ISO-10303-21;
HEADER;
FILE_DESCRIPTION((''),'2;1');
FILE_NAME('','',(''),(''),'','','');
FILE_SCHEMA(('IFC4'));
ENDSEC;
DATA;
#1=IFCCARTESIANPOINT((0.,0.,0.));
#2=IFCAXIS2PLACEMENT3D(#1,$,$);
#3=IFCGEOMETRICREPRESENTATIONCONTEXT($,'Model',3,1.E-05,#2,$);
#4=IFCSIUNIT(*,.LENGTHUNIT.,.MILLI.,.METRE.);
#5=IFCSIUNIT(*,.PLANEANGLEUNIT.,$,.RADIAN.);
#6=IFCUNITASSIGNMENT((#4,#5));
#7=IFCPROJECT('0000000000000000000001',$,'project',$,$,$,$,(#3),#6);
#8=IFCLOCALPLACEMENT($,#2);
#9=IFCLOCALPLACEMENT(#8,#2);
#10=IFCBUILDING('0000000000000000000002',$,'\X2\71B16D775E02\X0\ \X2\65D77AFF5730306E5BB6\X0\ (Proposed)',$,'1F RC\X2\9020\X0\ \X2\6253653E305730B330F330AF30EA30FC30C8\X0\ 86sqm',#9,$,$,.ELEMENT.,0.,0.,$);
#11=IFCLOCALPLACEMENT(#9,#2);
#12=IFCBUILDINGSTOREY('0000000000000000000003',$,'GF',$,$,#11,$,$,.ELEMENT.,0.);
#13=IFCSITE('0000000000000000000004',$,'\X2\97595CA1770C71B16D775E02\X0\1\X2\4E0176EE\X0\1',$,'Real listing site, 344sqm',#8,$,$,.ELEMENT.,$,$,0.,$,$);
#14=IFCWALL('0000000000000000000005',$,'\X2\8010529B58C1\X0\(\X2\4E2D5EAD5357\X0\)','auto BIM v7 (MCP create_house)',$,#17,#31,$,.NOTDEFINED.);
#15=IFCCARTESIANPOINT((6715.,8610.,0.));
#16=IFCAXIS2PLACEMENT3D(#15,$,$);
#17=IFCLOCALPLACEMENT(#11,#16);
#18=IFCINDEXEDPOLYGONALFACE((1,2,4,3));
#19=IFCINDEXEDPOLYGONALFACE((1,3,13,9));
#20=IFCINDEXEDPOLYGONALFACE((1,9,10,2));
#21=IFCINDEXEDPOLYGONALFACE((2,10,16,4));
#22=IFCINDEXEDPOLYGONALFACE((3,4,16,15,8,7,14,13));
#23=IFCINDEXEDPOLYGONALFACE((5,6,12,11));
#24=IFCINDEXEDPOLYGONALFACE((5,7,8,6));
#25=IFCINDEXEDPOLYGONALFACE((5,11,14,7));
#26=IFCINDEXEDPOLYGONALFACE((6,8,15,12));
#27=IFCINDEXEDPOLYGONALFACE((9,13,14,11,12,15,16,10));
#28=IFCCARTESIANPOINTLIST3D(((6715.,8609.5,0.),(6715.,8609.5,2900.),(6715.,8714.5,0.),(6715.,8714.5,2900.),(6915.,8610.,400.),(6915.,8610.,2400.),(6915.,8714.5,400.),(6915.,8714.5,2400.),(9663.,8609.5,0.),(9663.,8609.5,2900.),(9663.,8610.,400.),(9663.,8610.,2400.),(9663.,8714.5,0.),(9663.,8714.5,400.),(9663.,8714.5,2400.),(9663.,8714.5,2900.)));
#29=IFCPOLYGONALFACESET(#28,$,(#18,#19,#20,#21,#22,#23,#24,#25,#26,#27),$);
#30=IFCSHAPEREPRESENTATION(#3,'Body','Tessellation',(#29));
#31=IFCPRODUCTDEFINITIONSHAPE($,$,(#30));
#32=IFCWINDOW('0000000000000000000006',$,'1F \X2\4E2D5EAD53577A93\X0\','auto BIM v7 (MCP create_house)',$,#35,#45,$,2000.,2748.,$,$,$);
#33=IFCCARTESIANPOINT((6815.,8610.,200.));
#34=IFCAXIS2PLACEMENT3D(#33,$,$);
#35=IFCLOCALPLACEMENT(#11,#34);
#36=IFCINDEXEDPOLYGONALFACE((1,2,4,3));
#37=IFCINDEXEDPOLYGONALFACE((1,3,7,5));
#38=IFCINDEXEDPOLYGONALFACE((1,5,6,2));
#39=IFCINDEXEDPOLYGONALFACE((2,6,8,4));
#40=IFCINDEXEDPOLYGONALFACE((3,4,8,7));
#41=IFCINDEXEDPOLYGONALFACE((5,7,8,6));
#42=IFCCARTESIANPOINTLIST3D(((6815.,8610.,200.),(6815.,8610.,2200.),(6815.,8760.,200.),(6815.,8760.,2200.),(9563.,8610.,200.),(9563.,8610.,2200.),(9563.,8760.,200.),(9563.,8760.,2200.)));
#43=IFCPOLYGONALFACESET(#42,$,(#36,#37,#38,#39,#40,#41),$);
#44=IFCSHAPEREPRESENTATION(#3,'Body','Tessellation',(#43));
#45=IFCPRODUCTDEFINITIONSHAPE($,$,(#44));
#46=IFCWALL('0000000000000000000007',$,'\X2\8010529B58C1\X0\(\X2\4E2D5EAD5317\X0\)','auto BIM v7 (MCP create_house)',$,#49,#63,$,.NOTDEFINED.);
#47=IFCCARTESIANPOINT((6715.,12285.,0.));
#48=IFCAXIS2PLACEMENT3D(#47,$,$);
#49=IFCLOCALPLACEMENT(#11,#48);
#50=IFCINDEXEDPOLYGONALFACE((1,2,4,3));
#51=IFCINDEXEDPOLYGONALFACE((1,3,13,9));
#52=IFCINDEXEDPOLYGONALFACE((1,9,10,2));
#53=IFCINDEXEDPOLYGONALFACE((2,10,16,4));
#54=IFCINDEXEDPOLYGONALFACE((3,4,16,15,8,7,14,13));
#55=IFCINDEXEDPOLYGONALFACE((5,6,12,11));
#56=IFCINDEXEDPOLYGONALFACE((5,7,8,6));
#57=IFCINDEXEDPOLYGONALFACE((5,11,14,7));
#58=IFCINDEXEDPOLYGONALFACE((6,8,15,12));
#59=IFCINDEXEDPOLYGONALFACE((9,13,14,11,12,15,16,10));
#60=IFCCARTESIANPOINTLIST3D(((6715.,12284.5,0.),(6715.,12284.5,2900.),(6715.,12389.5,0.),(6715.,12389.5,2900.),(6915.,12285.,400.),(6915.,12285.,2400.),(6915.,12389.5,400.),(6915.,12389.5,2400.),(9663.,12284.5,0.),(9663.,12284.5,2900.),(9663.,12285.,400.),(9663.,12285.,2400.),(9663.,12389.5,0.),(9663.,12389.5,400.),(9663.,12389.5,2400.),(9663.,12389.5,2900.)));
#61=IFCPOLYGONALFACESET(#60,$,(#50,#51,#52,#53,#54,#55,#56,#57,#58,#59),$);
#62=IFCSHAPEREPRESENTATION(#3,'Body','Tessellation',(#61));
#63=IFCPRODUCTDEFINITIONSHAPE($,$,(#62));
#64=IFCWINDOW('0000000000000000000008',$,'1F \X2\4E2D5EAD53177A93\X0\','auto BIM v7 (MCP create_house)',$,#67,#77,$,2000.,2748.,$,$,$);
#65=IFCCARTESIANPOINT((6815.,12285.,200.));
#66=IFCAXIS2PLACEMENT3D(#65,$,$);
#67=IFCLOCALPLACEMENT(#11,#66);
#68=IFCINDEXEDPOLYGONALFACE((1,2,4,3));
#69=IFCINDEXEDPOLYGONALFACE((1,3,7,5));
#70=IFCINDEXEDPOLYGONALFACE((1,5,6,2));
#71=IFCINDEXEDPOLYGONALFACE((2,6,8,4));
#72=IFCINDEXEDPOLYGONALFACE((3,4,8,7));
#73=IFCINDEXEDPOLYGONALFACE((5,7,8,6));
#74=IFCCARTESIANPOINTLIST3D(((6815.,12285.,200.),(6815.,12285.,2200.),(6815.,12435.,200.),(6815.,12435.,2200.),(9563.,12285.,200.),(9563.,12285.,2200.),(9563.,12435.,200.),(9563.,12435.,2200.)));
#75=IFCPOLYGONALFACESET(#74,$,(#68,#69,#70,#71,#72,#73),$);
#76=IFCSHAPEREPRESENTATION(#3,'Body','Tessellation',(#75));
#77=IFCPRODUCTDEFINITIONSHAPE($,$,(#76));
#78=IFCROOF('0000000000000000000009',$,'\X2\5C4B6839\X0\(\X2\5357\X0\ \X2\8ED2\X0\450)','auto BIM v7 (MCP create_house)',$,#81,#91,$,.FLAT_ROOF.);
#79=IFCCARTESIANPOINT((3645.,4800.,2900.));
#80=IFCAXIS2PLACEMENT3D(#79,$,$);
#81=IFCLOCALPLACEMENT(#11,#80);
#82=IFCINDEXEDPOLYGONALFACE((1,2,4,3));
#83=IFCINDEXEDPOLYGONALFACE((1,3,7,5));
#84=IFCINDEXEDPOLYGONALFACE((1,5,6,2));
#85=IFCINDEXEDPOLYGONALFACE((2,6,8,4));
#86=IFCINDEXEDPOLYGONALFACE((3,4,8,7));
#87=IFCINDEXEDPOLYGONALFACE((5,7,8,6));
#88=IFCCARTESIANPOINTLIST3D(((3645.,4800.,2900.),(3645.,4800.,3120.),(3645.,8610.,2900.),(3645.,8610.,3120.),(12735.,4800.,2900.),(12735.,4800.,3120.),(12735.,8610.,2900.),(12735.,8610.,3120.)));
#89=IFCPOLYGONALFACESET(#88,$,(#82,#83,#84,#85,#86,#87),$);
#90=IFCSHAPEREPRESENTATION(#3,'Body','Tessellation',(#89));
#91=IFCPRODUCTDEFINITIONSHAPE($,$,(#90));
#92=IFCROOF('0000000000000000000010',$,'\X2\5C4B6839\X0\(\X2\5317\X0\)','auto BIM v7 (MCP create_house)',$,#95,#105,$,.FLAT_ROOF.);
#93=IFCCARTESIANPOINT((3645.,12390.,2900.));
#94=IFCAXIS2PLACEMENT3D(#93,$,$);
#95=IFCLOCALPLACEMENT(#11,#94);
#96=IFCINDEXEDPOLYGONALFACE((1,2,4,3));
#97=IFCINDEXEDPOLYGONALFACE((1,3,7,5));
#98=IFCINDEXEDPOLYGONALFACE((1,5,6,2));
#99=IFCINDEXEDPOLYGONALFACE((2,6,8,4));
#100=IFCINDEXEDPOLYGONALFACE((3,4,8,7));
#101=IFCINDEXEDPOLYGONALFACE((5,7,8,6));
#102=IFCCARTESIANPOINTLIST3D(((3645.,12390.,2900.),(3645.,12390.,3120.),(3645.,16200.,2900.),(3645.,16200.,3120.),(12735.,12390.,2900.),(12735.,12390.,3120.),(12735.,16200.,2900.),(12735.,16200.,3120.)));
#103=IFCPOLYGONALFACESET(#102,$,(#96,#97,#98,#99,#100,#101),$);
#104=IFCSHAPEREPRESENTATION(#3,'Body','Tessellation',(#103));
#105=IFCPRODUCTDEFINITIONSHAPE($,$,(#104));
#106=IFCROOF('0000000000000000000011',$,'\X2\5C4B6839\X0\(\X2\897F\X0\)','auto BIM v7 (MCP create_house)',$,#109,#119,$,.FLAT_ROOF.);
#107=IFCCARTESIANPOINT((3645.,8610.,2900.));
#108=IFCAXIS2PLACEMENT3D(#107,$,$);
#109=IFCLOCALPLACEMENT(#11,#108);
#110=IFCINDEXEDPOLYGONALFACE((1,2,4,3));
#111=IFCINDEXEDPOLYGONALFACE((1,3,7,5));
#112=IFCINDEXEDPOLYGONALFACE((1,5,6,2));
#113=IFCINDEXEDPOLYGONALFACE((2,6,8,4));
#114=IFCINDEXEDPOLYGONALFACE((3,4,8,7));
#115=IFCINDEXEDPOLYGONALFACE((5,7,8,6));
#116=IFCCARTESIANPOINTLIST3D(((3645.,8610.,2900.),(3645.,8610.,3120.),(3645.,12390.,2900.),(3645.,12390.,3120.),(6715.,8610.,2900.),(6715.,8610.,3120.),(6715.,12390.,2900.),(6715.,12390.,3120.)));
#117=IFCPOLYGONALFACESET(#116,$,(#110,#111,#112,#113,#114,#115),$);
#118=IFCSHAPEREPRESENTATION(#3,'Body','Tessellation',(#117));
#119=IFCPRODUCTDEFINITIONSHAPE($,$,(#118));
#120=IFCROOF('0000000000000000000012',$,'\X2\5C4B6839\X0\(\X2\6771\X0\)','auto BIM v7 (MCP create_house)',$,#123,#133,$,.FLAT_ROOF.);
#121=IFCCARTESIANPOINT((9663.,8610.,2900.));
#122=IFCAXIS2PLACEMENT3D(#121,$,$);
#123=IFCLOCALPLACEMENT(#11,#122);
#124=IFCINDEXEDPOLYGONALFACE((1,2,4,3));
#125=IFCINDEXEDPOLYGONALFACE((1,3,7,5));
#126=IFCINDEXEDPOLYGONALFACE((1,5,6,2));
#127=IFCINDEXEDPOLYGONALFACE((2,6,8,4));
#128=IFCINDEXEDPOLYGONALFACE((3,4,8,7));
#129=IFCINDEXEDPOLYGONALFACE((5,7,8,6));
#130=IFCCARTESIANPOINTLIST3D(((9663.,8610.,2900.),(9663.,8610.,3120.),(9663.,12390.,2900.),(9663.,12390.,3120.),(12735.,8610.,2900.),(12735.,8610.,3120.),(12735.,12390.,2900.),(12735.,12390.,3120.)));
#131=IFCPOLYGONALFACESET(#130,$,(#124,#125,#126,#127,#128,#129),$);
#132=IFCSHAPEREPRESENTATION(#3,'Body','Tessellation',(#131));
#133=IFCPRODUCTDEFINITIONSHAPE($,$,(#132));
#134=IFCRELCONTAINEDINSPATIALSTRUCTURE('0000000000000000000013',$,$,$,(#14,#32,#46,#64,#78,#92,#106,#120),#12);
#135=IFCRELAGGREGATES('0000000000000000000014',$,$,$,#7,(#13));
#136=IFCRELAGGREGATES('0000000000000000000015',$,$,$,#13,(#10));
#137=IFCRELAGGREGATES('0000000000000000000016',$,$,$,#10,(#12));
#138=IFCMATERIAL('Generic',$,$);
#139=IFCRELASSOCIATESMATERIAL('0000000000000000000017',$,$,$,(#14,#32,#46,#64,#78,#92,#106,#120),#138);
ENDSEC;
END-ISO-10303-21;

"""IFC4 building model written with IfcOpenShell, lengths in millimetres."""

from ifc_helpers import new_model, si_unit, frame, frame_2d, origin, place, context, project, spatial, rectangle, extrude, material, element, fill, save


model = new_model("IFC4")

# Units and contexts
model_context = context("Model", 3, precision=1e-05, world=origin())
ifc_project = project(units=[si_unit("LENGTHUNIT", "METRE", prefix="MILLI"), si_unit("PLANEANGLEUNIT", "RADIAN")], contexts=[model_context])

# Site, building, storey
site_placement = place(None, origin())
site = spatial("IfcSite", under=ifc_project, at=site_placement, Name="静岡県熱海市1丁目1", ObjectType="Real listing site, 344sqm", CompositionType="ELEMENT", RefElevation=0.0)
building_placement = place(site_placement, origin())
building = spatial("IfcBuilding", under=site, at=building_placement, Name="熱海市 旗竿地の家 (Proposed)", ObjectType="1F RC造 打放しコンクリート 86sqm", CompositionType="ELEMENT", ElevationOfRefHeight=0.0, ElevationOfTerrain=0.0)
storey_placement = place(building_placement, origin())
storey = spatial("IfcBuildingStorey", under=building, at=storey_placement, Name="GF", CompositionType="ELEMENT", Elevation=0.0)

# Shared definitions
ifc_material = material(Name="Generic")

# Walls, openings, windows
wall_1_placement = place(storey_placement, frame((6715.0, 8610.0, 0.0)))
wall_1 = element("IfcWall", 1, at=wall_1_placement, inside=storey, material=ifc_material, Name="耐力壁(中庭南)", Description="auto BIM v7 (MCP create_house)", PredefinedType="NOTDEFINED", context=model_context, shape_type="SweptSolid", body=[
    extrude(rectangle(XDim=2948.0, YDim=105.0, at=frame_2d((1474.0, 52.0))), frame((6715.0, 8610.0, 0.0)), (0.0, 0.0, 1.0), 2900.0),
])
opening_1_placement = place(storey_placement, frame((6815.0, 8610.0, 200.0)))
opening_1 = element("IfcOpeningElement", 2, at=opening_1_placement, cuts=wall_1, PredefinedType="NOTDEFINED", context=model_context, shape_type="SweptSolid", body=[
    extrude(rectangle(XDim=2748.0, YDim=150.0, at=frame_2d((1374.0, 75.0))), frame((6815.0, 8610.0, 200.0)), (0.0, 0.0, 1.0), 2000.0),
])
window_1_placement = place(storey_placement, frame((6815.0, 8610.0, 200.0)))
window_1 = element("IfcWindow", 3, at=window_1_placement, inside=storey, material=ifc_material, Name="1F 中庭南窓", Description="auto BIM v7 (MCP create_house)", OverallHeight=2000.0, OverallWidth=2748.0, context=model_context, shape_type="SweptSolid", body=[
    extrude(rectangle(XDim=2748.0, YDim=150.0, at=frame_2d((1374.0, 75.0))), frame((6815.0, 8610.0, 200.0)), (0.0, 0.0, 1.0), 2000.0),
])
fill(opening_1, window_1)
wall_2_placement = place(storey_placement, frame((6715.0, 12285.0, 0.0)))
wall_2 = element("IfcWall", 4, at=wall_2_placement, inside=storey, material=ifc_material, Name="耐力壁(中庭北)", Description="auto BIM v7 (MCP create_house)", PredefinedType="NOTDEFINED", context=model_context, shape_type="SweptSolid", body=[
    extrude(rectangle(XDim=2948.0, YDim=105.0, at=frame_2d((1474.0, 52.0))), frame((6715.0, 12285.0, 0.0)), (0.0, 0.0, 1.0), 2900.0),
])
opening_2_placement = place(storey_placement, frame((6815.0, 12285.0, 200.0)))
opening_2 = element("IfcOpeningElement", 5, at=opening_2_placement, cuts=wall_2, PredefinedType="NOTDEFINED", context=model_context, shape_type="SweptSolid", body=[
    extrude(rectangle(XDim=2748.0, YDim=150.0, at=frame_2d((1374.0, 75.0))), frame((6815.0, 12285.0, 200.0)), (0.0, 0.0, 1.0), 2000.0),
])
window_2_placement = place(storey_placement, frame((6815.0, 12285.0, 200.0)))
window_2 = element("IfcWindow", 6, at=window_2_placement, inside=storey, material=ifc_material, Name="1F 中庭北窓", Description="auto BIM v7 (MCP create_house)", OverallHeight=2000.0, OverallWidth=2748.0, context=model_context, shape_type="SweptSolid", body=[
    extrude(rectangle(XDim=2748.0, YDim=150.0, at=frame_2d((1374.0, 75.0))), frame((6815.0, 12285.0, 200.0)), (0.0, 0.0, 1.0), 2000.0),
])
fill(opening_2, window_2)

# Roofs
roof_1_placement = place(storey_placement, frame((3645.0, 4800.0, 2900.0)))
element("IfcRoof", 7, at=roof_1_placement, inside=storey, material=ifc_material, Name="屋根(南 軒450)", Description="auto BIM v7 (MCP create_house)", PredefinedType="FLAT_ROOF", context=model_context, shape_type="SweptSolid", body=[
    extrude(rectangle(XDim=9090.0, YDim=3810.0, at=frame_2d((4545.0, 1905.0))), frame((3645.0, 4800.0, 2900.0)), (0.0, 0.0, 1.0), 220.0),
])
roof_2_placement = place(storey_placement, frame((3645.0, 12390.0, 2900.0)))
element("IfcRoof", 8, at=roof_2_placement, inside=storey, material=ifc_material, Name="屋根(北)", Description="auto BIM v7 (MCP create_house)", PredefinedType="FLAT_ROOF", context=model_context, shape_type="SweptSolid", body=[
    extrude(rectangle(XDim=9090.0, YDim=3810.0, at=frame_2d((4545.0, 1905.0))), frame((3645.0, 12390.0, 2900.0)), (0.0, 0.0, 1.0), 220.0),
])
roof_3_placement = place(storey_placement, frame((3645.0, 8610.0, 2900.0)))
element("IfcRoof", 9, at=roof_3_placement, inside=storey, material=ifc_material, Name="屋根(西)", Description="auto BIM v7 (MCP create_house)", PredefinedType="FLAT_ROOF", context=model_context, shape_type="SweptSolid", body=[
    extrude(rectangle(XDim=3070.0, YDim=3780.0, at=frame_2d((1535.0, 1890.0))), frame((3645.0, 8610.0, 2900.0)), (0.0, 0.0, 1.0), 220.0),
])
roof_4_placement = place(storey_placement, frame((9663.0, 8610.0, 2900.0)))
element("IfcRoof", 10, at=roof_4_placement, inside=storey, material=ifc_material, Name="屋根(東)", Description="auto BIM v7 (MCP create_house)", PredefinedType="FLAT_ROOF", context=model_context, shape_type="SweptSolid", body=[
    extrude(rectangle(XDim=3072.0, YDim=3780.0, at=frame_2d((1536.0, 1890.0))), frame((9663.0, 8610.0, 2900.0)), (0.0, 0.0, 1.0), 220.0),
])

save(model, "model.ifc")
